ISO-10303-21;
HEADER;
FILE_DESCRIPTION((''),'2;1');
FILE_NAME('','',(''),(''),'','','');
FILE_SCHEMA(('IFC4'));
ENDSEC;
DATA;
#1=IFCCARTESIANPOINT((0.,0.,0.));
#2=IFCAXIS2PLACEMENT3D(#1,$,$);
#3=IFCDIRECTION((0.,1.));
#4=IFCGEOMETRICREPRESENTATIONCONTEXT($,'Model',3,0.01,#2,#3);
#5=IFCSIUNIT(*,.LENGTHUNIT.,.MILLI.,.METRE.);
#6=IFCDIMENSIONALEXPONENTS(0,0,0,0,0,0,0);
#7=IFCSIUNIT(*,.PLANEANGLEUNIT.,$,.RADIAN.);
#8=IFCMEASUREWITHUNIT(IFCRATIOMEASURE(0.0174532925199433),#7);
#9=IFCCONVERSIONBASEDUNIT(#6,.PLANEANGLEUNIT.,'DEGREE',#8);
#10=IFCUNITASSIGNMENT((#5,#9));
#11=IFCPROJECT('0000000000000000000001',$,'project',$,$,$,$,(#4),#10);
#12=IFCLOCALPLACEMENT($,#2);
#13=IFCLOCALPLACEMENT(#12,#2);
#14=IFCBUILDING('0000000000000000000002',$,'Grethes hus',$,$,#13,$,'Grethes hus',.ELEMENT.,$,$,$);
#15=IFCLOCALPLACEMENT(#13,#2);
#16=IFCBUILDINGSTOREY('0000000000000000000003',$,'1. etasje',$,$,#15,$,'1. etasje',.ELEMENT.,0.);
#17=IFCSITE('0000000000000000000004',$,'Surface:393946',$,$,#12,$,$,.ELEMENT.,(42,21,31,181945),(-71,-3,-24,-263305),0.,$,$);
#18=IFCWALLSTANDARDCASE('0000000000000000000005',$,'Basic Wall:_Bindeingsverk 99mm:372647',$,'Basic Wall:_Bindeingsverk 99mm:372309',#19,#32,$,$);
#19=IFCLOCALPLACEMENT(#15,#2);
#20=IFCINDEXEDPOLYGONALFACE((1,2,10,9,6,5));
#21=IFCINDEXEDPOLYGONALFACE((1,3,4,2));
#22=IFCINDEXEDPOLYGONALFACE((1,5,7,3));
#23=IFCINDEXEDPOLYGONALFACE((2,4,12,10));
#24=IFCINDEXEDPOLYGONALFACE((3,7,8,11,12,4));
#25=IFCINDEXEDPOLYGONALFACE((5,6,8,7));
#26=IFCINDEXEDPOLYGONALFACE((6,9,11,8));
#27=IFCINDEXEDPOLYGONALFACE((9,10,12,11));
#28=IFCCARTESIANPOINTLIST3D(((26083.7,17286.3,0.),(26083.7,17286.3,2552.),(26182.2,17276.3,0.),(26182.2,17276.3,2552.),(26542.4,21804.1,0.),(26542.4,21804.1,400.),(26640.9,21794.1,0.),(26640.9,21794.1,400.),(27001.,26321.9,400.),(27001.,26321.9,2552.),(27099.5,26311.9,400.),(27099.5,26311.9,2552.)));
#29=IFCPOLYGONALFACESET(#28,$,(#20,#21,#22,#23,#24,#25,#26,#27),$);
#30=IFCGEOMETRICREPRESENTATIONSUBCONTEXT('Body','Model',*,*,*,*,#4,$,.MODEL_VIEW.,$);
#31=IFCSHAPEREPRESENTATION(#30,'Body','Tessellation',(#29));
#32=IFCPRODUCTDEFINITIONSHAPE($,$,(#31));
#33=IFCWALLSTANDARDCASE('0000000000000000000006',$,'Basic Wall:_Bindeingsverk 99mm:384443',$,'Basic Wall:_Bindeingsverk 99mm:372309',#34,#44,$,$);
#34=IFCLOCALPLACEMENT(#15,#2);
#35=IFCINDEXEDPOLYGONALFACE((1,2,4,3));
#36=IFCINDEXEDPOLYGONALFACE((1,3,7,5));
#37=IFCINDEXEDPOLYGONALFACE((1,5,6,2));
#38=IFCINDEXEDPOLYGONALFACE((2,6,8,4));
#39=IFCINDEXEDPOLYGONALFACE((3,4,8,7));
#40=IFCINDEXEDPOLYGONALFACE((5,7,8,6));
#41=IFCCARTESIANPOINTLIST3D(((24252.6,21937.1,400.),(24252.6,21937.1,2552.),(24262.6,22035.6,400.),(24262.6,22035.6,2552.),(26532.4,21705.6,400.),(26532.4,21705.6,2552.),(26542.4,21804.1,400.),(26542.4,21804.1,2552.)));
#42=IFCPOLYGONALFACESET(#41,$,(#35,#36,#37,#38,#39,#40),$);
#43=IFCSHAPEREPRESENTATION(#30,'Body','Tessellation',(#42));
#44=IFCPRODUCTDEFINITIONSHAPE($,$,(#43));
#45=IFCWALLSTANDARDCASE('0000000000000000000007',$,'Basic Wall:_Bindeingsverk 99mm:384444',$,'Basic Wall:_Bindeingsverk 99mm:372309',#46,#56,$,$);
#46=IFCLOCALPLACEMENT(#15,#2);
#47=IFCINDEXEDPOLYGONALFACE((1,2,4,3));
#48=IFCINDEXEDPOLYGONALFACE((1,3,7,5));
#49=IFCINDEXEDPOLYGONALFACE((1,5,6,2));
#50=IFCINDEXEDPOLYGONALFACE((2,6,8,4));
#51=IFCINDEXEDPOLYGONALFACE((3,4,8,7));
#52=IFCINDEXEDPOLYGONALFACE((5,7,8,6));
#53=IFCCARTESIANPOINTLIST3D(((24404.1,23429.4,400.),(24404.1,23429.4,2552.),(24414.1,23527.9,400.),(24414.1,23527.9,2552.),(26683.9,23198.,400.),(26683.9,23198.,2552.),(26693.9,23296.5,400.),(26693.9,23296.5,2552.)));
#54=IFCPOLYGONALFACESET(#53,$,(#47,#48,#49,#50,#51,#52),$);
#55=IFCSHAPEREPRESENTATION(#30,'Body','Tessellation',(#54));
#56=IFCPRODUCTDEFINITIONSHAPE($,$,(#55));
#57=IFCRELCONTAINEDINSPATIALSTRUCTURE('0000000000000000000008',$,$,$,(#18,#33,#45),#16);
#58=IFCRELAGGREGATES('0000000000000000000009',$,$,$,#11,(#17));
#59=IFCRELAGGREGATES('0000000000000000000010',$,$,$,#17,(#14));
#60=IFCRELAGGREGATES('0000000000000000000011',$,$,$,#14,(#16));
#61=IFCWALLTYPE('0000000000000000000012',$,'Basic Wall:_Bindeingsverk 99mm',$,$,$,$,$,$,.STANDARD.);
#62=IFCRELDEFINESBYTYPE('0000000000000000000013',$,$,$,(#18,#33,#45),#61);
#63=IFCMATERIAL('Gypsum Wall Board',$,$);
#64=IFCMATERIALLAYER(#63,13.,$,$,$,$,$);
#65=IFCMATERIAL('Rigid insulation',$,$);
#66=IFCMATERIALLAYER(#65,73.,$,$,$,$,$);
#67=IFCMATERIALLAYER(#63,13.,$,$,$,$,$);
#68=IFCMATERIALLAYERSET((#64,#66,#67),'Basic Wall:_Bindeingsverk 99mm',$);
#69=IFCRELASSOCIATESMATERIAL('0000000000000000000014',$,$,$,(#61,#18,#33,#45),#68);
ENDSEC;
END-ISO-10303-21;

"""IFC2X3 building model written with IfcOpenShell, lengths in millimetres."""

from ifc_helpers import new_model, entity, si_unit, converted_unit, direction, frame, frame_2d, origin, place, context, subcontext, project, spatial, polyline, rectangle, extrude, clip, bounded_halfspace, material, layer, layer_set, layer_usage, type_object, element, save


model = new_model("IFC2X3")

# Units and contexts
model_context = context("Model", 3, precision=0.01, world=origin(), true_north=direction((0.0, 1.0)))
body_context = subcontext(model_context, "Body", "Model", "MODEL_VIEW")
ifc_project = project(units=[si_unit("LENGTHUNIT", "METRE", prefix="MILLI"), converted_unit("PLANEANGLEUNIT", "DEGREE", entity("IfcRatioMeasure", 0.0174532925199433), si_unit("PLANEANGLEUNIT", "RADIAN"), dimensions=[0, 0, 0, 0, 0, 0, 0])], contexts=[model_context])

# Site, building, storey
site_placement = place(None, origin())
site = spatial("IfcSite", under=ifc_project, at=site_placement, Name="Surface:393946", CompositionType="ELEMENT", RefLatitude=(42, 21, 31, 181945), RefLongitude=(-71, -3, -24, -263305), RefElevation=0.0)
building_placement = place(site_placement, origin())
building = spatial("IfcBuilding", under=site, at=building_placement, Name="Grethes hus", LongName="Grethes hus", CompositionType="ELEMENT")
storey_placement = place(building_placement, origin())
storey = spatial("IfcBuildingStorey", under=building, at=storey_placement, Name="1. etasje", LongName="1. etasje", CompositionType="ELEMENT", Elevation=0.0)

# Wall, opening
ifc_material_1 = material(Name="Gypsum Wall Board")
ifc_layer_1 = layer(ifc_material_1, 13.0)
ifc_material_2 = material(Name="Rigid insulation")
ifc_layer_2 = layer(ifc_material_2, 73.0)
ifc_layer_3 = layer(ifc_material_1, 13.0)
ifc_layer_set = layer_set([ifc_layer_1, ifc_layer_2, ifc_layer_3], Name="Basic Wall:_Bindeingsverk 99mm")
ifc_layer_usage_1 = layer_usage(ifc_layer_set, "AXIS2", "NEGATIVE", 49.5)
wall_type = type_object("IfcWallType", Name="Basic Wall:_Bindeingsverk 99mm", PredefinedType="STANDARD", material=ifc_layer_set)
wall_1_placement = place(storey_placement, frame((26133.0, 17281.3, 0.0), z_axis=(0.0, 0.0, 1.0), x_axis=(0.100996, 0.994887, 0.0)))
wall_1 = element("IfcWallStandardCase", 1, at=wall_1_placement, inside=storey, type_object=wall_type, material=ifc_layer_usage_1, Name="Basic Wall:_Bindeingsverk 99mm:372647", ObjectType="Basic Wall:_Bindeingsverk 99mm:372309", context=body_context, shape_type="Clipping", body=[
    clip(extrude(rectangle(XDim=9082.0, YDim=99.0, at=frame_2d((4541.0, 0.0), x_axis=(-1.0, 0.0))), origin(), (0.0, 0.0, 1.0), 2552.0), bounded_halfspace(frame((0.0, -49.5, 2552.0), z_axis=(0.0, 0.0, -1.0), x_axis=(0.0, -1.0, 0.0)), True, frame((0.0, -49.5, 2552.0)), polyline([(0.0, 0.0), (9082.0, 0.0), (9082.0, 99.0), (0.0, 99.0), (0.0, 0.0)]))),
])
opening_1_placement = place(wall_1_placement, origin())
element("IfcOpeningElement", 2, at=opening_1_placement, cuts=wall_1, ObjectType="Opening", context=body_context, shape_type="SweptSolid", body=[
    extrude(rectangle(XDim=400.0, YDim=4699.0, at=frame_2d((0.0, 0.0), x_axis=(0.0, 1.0))), frame((6890.5, 49.5, 200.0), z_axis=(0.0, -1.0, 0.0), x_axis=(1.0, 0.0, 0.0)), (0.0, 0.0, 1.0), 99.0),
])

# Walls
ifc_layer_usage_2 = layer_usage(ifc_layer_set, "AXIS2", "POSITIVE", -49.5)
wall_2_placement = place(storey_placement, frame((24257.6, 21986.3, 400.0), z_axis=(0.0, 0.0, 1.0), x_axis=(0.994887, -0.100996, 0.0)))
element("IfcWallStandardCase", 3, at=wall_2_placement, inside=storey, type_object=wall_type, material=ifc_layer_usage_2, Name="Basic Wall:_Bindeingsverk 99mm:384443", ObjectType="Basic Wall:_Bindeingsverk 99mm:372309", context=body_context, shape_type="Clipping", body=[
    clip(extrude(rectangle(XDim=2291.5, YDim=99.0, at=frame_2d((1145.8, 0.0), x_axis=(-1.0, 0.0))), origin(), (0.0, 0.0, 1.0), 2152.0), bounded_halfspace(frame((0.0, -49.5, 2152.0), z_axis=(0.0, 0.0, -1.0), x_axis=(1.0, 0.0, 0.0)), True, frame((0.0, -49.5, 2152.0)), polyline([(0.0, 0.0), (2291.5, 0.0), (2291.5, 99.0), (0.0, 99.0), (0.0, 0.0)]))),
])
ifc_layer_usage_3 = layer_usage(ifc_layer_set, "AXIS2", "POSITIVE", -49.5)
wall_3_placement = place(storey_placement, frame((24409.1, 23478.6, 400.0), z_axis=(0.0, 0.0, 1.0), x_axis=(0.994887, -0.100996, 0.0)))
element("IfcWallStandardCase", 4, at=wall_3_placement, inside=storey, type_object=wall_type, material=ifc_layer_usage_3, Name="Basic Wall:_Bindeingsverk 99mm:384444", ObjectType="Basic Wall:_Bindeingsverk 99mm:372309", context=body_context, shape_type="Clipping", body=[
    clip(extrude(rectangle(XDim=2291.5, YDim=99.0, at=frame_2d((1145.8, 0.0), x_axis=(-1.0, 0.0))), origin(), (0.0, 0.0, 1.0), 2152.0), bounded_halfspace(frame((0.0, -49.5, 2152.0), z_axis=(0.0, 0.0, -1.0), x_axis=(1.0, 0.0, 0.0)), True, frame((0.0, -49.5, 2152.0)), polyline([(0.0, 0.0), (2291.5, 0.0), (2291.5, 99.0), (0.0, 99.0), (0.0, 0.0)]))),
])

save(model, "model.ifc")
